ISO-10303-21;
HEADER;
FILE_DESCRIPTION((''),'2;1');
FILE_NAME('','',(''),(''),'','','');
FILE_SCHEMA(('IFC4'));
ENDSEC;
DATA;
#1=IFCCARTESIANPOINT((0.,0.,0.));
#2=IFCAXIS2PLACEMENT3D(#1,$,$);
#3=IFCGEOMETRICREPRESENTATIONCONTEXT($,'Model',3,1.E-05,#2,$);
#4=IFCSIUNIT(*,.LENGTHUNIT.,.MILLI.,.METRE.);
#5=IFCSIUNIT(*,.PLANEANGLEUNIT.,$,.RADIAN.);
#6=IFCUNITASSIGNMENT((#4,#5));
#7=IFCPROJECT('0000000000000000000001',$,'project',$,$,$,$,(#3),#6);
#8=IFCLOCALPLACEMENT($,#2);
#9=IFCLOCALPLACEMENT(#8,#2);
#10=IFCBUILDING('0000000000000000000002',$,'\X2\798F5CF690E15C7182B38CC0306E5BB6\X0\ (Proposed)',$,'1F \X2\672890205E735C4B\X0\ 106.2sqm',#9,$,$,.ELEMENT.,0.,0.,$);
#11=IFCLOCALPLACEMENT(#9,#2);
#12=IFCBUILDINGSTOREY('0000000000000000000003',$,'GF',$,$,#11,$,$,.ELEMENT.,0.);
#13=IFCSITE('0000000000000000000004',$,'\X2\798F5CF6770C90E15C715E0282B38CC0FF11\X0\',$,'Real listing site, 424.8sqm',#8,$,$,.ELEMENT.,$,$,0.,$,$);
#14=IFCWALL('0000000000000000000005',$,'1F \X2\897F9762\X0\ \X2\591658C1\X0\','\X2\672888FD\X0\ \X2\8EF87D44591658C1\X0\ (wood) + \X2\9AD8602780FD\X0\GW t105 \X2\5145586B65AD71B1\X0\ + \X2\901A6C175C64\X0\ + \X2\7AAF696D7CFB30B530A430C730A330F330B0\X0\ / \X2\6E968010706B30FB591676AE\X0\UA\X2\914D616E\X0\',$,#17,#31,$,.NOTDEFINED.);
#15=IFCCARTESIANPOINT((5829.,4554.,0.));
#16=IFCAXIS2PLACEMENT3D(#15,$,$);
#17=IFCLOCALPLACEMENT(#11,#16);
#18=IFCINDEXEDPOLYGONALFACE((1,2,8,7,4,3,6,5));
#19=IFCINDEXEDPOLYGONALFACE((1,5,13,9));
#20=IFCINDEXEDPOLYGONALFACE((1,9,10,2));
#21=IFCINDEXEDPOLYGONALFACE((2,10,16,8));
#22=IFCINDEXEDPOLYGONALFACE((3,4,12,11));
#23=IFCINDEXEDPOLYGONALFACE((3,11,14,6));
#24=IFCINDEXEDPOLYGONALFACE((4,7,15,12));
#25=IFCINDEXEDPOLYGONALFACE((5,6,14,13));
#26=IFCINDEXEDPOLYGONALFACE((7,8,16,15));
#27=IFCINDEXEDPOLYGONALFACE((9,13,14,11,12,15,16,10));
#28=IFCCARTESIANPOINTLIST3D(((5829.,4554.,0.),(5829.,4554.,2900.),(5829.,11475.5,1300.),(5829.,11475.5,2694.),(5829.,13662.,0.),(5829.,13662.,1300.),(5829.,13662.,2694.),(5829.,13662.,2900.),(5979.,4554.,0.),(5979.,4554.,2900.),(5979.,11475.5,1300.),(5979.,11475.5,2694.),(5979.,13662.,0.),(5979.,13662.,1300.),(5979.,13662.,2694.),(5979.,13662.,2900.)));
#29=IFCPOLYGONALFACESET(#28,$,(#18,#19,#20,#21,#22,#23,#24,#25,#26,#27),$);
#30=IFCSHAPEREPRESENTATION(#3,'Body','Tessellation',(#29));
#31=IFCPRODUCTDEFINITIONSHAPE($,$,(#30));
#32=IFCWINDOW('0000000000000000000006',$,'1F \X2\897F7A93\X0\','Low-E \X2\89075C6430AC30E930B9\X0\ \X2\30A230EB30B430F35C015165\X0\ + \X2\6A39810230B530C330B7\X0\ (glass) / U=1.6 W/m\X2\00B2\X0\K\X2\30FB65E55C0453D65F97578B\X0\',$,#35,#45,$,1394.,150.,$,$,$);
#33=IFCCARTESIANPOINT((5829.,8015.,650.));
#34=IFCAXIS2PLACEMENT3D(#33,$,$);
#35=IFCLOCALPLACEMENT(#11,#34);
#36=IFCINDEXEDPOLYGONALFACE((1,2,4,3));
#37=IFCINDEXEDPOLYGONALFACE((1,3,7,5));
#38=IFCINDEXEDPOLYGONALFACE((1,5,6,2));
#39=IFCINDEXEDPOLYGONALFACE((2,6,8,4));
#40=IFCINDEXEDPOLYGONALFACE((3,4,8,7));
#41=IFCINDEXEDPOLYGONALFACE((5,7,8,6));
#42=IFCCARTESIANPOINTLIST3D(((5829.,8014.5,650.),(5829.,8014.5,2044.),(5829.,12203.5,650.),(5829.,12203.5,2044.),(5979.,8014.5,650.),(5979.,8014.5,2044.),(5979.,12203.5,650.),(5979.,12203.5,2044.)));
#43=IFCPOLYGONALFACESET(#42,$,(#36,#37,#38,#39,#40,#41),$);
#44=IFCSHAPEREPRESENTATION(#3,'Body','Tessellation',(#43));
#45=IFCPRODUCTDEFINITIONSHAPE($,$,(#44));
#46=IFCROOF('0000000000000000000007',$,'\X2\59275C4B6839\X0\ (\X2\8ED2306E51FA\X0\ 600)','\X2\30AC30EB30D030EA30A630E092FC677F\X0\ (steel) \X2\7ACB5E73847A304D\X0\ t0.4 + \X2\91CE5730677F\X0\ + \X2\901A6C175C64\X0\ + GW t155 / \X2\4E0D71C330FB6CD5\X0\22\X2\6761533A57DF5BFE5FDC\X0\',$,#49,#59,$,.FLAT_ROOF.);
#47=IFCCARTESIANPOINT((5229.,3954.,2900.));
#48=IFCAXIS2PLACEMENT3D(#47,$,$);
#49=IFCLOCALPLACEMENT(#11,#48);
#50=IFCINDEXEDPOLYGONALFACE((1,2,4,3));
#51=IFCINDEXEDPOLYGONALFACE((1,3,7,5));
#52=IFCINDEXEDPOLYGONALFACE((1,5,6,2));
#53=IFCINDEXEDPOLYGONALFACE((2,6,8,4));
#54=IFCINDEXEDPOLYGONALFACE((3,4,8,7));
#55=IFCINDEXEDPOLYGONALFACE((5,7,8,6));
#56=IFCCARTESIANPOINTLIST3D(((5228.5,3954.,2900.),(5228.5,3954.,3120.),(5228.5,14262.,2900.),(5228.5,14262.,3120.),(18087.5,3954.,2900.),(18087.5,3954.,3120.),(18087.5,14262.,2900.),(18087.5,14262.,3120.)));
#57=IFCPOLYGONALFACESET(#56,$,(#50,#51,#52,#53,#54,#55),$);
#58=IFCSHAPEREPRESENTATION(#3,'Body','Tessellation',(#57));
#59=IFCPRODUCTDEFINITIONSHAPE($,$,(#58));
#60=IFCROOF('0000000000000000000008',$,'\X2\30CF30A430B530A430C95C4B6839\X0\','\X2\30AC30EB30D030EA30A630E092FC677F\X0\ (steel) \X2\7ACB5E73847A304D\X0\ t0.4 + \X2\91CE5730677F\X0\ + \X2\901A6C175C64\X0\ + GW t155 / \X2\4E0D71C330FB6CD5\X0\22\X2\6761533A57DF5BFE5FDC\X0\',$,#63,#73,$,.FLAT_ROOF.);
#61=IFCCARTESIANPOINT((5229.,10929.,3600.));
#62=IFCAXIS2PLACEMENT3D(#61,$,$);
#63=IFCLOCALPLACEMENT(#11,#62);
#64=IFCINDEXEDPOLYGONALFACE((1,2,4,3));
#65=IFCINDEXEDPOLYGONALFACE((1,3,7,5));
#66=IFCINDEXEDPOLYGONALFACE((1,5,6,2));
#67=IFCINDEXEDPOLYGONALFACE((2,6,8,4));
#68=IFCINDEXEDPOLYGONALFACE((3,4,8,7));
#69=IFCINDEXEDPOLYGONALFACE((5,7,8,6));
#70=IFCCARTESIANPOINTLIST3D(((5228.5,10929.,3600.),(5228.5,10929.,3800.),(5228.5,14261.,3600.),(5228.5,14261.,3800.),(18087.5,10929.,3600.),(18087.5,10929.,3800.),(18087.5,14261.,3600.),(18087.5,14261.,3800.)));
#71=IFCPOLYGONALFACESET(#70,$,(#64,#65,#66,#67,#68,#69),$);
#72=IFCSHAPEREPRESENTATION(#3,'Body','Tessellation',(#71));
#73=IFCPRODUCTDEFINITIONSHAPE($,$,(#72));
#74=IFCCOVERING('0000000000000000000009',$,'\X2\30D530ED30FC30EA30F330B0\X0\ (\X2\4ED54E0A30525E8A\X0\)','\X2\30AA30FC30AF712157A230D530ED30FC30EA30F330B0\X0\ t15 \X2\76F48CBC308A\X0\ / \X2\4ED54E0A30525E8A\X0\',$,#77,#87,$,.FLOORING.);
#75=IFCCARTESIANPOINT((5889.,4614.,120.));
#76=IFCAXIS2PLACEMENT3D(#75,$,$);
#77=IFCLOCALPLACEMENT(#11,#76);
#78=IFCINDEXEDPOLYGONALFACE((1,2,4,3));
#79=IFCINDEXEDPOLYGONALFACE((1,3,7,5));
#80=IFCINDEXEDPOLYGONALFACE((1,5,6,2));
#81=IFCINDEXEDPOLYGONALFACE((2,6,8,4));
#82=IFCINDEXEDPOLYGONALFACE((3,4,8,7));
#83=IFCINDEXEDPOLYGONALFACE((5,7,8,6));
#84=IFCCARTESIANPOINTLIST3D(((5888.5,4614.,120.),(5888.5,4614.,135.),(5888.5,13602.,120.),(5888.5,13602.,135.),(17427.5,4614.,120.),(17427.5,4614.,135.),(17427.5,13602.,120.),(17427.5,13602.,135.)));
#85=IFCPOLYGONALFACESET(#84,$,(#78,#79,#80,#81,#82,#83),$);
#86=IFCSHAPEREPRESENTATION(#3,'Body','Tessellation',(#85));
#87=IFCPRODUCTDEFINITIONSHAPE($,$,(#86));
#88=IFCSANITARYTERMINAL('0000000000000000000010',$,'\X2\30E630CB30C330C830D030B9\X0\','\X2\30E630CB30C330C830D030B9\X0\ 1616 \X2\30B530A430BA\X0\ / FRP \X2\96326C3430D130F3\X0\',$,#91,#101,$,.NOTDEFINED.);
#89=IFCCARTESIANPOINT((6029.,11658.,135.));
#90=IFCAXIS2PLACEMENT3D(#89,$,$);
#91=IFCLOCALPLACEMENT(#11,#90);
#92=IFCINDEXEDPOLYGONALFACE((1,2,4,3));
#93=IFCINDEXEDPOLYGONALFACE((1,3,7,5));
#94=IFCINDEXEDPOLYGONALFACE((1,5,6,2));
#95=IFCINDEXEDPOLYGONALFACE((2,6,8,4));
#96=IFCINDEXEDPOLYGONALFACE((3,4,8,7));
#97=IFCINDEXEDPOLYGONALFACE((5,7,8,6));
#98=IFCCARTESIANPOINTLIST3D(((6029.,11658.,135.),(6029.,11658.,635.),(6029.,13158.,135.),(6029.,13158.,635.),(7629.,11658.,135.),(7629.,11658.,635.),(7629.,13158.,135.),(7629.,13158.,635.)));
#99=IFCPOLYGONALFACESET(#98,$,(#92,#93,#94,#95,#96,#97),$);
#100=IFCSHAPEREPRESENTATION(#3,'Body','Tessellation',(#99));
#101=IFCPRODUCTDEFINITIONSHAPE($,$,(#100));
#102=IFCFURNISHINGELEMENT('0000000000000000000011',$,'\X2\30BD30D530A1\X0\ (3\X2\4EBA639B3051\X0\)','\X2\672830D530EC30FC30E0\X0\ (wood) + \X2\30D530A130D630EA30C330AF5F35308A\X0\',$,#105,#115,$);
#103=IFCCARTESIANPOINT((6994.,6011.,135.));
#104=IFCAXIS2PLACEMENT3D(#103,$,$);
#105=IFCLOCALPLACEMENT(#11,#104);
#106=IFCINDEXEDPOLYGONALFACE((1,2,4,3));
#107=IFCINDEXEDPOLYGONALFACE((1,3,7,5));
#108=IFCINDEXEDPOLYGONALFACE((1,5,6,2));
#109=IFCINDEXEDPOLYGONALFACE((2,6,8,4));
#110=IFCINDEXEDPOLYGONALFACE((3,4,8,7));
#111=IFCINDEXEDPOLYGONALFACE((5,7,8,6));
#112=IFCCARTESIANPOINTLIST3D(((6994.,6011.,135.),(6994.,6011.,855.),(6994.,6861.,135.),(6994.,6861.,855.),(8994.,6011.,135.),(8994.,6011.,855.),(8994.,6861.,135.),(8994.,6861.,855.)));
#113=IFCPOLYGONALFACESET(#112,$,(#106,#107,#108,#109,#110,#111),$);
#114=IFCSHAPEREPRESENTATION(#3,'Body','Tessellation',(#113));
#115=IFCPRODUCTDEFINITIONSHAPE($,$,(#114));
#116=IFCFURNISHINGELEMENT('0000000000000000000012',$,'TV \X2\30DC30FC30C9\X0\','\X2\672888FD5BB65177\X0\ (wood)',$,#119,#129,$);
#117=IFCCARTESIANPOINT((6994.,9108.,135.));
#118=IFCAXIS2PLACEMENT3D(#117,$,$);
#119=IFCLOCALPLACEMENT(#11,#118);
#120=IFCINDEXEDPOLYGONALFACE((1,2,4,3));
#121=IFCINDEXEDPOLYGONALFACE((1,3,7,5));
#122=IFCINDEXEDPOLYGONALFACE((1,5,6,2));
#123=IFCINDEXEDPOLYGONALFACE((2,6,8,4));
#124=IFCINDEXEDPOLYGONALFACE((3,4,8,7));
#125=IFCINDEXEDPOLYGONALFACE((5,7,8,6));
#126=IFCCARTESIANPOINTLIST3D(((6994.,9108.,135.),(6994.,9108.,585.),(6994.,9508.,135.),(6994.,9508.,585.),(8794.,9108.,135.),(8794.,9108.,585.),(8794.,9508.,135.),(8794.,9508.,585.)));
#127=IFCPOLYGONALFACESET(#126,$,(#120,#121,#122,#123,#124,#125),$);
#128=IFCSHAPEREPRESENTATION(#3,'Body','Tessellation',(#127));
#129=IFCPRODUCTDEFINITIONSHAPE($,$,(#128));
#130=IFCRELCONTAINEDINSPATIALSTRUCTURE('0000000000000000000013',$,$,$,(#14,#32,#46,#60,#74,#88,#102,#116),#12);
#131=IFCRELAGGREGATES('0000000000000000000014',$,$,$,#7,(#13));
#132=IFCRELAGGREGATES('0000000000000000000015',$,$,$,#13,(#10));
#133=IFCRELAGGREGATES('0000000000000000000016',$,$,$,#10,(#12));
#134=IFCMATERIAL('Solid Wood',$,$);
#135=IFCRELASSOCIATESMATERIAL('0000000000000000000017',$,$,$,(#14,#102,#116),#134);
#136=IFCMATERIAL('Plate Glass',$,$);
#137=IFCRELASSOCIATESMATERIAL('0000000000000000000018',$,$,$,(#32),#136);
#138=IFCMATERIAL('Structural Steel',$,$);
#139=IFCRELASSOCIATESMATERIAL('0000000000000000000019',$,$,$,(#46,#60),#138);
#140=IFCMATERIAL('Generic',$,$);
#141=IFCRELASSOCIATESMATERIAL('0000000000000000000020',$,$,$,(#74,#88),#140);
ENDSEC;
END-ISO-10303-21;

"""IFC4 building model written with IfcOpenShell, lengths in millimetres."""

from ifc_helpers import new_model, si_unit, frame, frame_2d, origin, place, context, project, spatial, rectangle, extrude, material, element, fill, save


model = new_model("IFC4")

# Units and contexts
model_context = context("Model", 3, precision=1e-05, world=origin())
ifc_project = project(units=[si_unit("LENGTHUNIT", "METRE", prefix="MILLI"), si_unit("PLANEANGLEUNIT", "RADIAN")], contexts=[model_context])

# Site, building, storey
site_placement = place(None, origin())
site = spatial("IfcSite", under=ifc_project, at=site_placement, Name="福島県郡山市芳賀１", ObjectType="Real listing site, 424.8sqm", CompositionType="ELEMENT", RefElevation=0.0)
building_placement = place(site_placement, origin())
building = spatial("IfcBuilding", under=site, at=building_placement, Name="福島郡山芳賀の家 (Proposed)", ObjectType="1F 木造平屋 106.2sqm", CompositionType="ELEMENT", ElevationOfRefHeight=0.0, ElevationOfTerrain=0.0)
storey_placement = place(building_placement, origin())
storey = spatial("IfcBuildingStorey", under=building, at=storey_placement, Name="GF", CompositionType="ELEMENT", Elevation=0.0)

# Shared definitions
ifc_material_1 = material(Name="Solid Wood")

# Shared definitions
ifc_material_2 = material(Name="Plate Glass")

# Wall, opening, window
wall_1_placement = place(storey_placement, frame((5829.0, 4554.0, 0.0)))
wall_1 = element("IfcWall", 1, at=wall_1_placement, inside=storey, material=ifc_material_1, Name="1F 西面 外壁", Description="木製 軸組外壁 (wood) + 高性能GW t105 充填断熱 + 通気層 + 窯業系サイディング / 準耐火・外皮UA配慮", PredefinedType="NOTDEFINED", context=model_context, shape_type="SweptSolid", body=[
    extrude(rectangle(XDim=150.0, YDim=9108.0, at=frame_2d((75.0, 4554.0))), frame((5829.0, 4554.0, 0.0)), (0.0, 0.0, 1.0), 2900.0),
])
opening_1_placement = place(storey_placement, frame((5829.0, 8015.0, 650.0)))
opening_1 = element("IfcOpeningElement", 2, at=opening_1_placement, cuts=wall_1, PredefinedType="NOTDEFINED", context=model_context, shape_type="SweptSolid", body=[
    extrude(rectangle(XDim=150.0, YDim=4189.0, at=frame_2d((75.0, 2094.0))), frame((5829.0, 8015.0, 650.0)), (0.0, 0.0, 1.0), 1394.0),
])
window_1_placement = place(storey_placement, frame((5829.0, 8015.0, 650.0)))
window_1 = element("IfcWindow", 3, at=window_1_placement, inside=storey, material=ifc_material_2, Name="1F 西窓", Description="Low-E 複層ガラス アルゴン封入 + 樹脂サッシ (glass) / U=1.6 W/m²K・日射取得型", OverallHeight=1394.0, OverallWidth=150.0, context=model_context, shape_type="SweptSolid", body=[
    extrude(rectangle(XDim=150.0, YDim=4189.0, at=frame_2d((75.0, 2094.0))), frame((5829.0, 8015.0, 650.0)), (0.0, 0.0, 1.0), 1394.0),
])
fill(opening_1, window_1)

# Roofs
ifc_material_3 = material(Name="Structural Steel")
roof_1_placement = place(storey_placement, frame((5229.0, 3954.0, 2900.0)))
element("IfcRoof", 4, at=roof_1_placement, inside=storey, material=ifc_material_3, Name="大屋根 (軒の出 600)", Description="ガルバリウム鋼板 (steel) 立平葺き t0.4 + 野地板 + 通気層 + GW t155 / 不燃・法22条区域対応", PredefinedType="FLAT_ROOF", context=model_context, shape_type="SweptSolid", body=[
    extrude(rectangle(XDim=12859.0, YDim=10308.0, at=frame_2d((6429.0, 5154.0))), frame((5229.0, 3954.0, 2900.0)), (0.0, 0.0, 1.0), 220.0),
])
roof_2_placement = place(storey_placement, frame((5229.0, 10929.0, 3600.0)))
element("IfcRoof", 5, at=roof_2_placement, inside=storey, material=ifc_material_3, Name="ハイサイド屋根", Description="ガルバリウム鋼板 (steel) 立平葺き t0.4 + 野地板 + 通気層 + GW t155 / 不燃・法22条区域対応", PredefinedType="FLAT_ROOF", context=model_context, shape_type="SweptSolid", body=[
    extrude(rectangle(XDim=12859.0, YDim=3332.0, at=frame_2d((6429.0, 1666.0))), frame((5229.0, 10929.0, 3600.0)), (0.0, 0.0, 1.0), 200.0),
])

# Covering
ifc_material_4 = material(Name="Generic")
covering_placement = place(storey_placement, frame((5889.0, 4614.0, 120.0)))
element("IfcCovering", 6, at=covering_placement, inside=storey, material=ifc_material_4, Name="フローリング (仕上げ床)", Description="オーク無垢フローリング t15 直貼り / 仕上げ床", PredefinedType="FLOORING", context=model_context, shape_type="SweptSolid", body=[
    extrude(rectangle(XDim=11539.0, YDim=8988.0, at=frame_2d((5769.0, 4494.0))), frame((5889.0, 4614.0, 120.0)), (0.0, 0.0, 1.0), 15.0),
])

# Sanitary terminal
sanitary_terminal_placement = place(storey_placement, frame((6029.0, 11658.0, 135.0)))
element("IfcSanitaryTerminal", 7, at=sanitary_terminal_placement, inside=storey, material=ifc_material_4, Name="ユニットバス", Description="ユニットバス 1616 サイズ / FRP 防水パン", PredefinedType="NOTDEFINED", context=model_context, shape_type="SweptSolid", body=[
    extrude(rectangle(XDim=1600.0, YDim=1500.0, at=frame_2d((800.0, 750.0))), frame((6029.0, 11658.0, 135.0)), (0.0, 0.0, 1.0), 500.0),
])

# Furnishing elements
furnishing_1_placement = place(storey_placement, frame((6994.0, 6011.0, 135.0)))
element("IfcFurnishingElement", 8, at=furnishing_1_placement, inside=storey, material=ifc_material_1, Name="ソファ (3人掛け)", Description="木フレーム (wood) + ファブリック張り", context=model_context, shape_type="SweptSolid", body=[
    extrude(rectangle(XDim=2000.0, YDim=850.0, at=frame_2d((1000.0, 425.0))), frame((6994.0, 6011.0, 135.0)), (0.0, 0.0, 1.0), 720.0),
])
furnishing_2_placement = place(storey_placement, frame((6994.0, 9108.0, 135.0)))
element("IfcFurnishingElement", 9, at=furnishing_2_placement, inside=storey, material=ifc_material_1, Name="TV ボード", Description="木製家具 (wood)", context=model_context, shape_type="SweptSolid", body=[
    extrude(rectangle(XDim=1800.0, YDim=400.0, at=frame_2d((900.0, 200.0))), frame((6994.0, 9108.0, 135.0)), (0.0, 0.0, 1.0), 450.0),
])

save(model, "model.ifc")
